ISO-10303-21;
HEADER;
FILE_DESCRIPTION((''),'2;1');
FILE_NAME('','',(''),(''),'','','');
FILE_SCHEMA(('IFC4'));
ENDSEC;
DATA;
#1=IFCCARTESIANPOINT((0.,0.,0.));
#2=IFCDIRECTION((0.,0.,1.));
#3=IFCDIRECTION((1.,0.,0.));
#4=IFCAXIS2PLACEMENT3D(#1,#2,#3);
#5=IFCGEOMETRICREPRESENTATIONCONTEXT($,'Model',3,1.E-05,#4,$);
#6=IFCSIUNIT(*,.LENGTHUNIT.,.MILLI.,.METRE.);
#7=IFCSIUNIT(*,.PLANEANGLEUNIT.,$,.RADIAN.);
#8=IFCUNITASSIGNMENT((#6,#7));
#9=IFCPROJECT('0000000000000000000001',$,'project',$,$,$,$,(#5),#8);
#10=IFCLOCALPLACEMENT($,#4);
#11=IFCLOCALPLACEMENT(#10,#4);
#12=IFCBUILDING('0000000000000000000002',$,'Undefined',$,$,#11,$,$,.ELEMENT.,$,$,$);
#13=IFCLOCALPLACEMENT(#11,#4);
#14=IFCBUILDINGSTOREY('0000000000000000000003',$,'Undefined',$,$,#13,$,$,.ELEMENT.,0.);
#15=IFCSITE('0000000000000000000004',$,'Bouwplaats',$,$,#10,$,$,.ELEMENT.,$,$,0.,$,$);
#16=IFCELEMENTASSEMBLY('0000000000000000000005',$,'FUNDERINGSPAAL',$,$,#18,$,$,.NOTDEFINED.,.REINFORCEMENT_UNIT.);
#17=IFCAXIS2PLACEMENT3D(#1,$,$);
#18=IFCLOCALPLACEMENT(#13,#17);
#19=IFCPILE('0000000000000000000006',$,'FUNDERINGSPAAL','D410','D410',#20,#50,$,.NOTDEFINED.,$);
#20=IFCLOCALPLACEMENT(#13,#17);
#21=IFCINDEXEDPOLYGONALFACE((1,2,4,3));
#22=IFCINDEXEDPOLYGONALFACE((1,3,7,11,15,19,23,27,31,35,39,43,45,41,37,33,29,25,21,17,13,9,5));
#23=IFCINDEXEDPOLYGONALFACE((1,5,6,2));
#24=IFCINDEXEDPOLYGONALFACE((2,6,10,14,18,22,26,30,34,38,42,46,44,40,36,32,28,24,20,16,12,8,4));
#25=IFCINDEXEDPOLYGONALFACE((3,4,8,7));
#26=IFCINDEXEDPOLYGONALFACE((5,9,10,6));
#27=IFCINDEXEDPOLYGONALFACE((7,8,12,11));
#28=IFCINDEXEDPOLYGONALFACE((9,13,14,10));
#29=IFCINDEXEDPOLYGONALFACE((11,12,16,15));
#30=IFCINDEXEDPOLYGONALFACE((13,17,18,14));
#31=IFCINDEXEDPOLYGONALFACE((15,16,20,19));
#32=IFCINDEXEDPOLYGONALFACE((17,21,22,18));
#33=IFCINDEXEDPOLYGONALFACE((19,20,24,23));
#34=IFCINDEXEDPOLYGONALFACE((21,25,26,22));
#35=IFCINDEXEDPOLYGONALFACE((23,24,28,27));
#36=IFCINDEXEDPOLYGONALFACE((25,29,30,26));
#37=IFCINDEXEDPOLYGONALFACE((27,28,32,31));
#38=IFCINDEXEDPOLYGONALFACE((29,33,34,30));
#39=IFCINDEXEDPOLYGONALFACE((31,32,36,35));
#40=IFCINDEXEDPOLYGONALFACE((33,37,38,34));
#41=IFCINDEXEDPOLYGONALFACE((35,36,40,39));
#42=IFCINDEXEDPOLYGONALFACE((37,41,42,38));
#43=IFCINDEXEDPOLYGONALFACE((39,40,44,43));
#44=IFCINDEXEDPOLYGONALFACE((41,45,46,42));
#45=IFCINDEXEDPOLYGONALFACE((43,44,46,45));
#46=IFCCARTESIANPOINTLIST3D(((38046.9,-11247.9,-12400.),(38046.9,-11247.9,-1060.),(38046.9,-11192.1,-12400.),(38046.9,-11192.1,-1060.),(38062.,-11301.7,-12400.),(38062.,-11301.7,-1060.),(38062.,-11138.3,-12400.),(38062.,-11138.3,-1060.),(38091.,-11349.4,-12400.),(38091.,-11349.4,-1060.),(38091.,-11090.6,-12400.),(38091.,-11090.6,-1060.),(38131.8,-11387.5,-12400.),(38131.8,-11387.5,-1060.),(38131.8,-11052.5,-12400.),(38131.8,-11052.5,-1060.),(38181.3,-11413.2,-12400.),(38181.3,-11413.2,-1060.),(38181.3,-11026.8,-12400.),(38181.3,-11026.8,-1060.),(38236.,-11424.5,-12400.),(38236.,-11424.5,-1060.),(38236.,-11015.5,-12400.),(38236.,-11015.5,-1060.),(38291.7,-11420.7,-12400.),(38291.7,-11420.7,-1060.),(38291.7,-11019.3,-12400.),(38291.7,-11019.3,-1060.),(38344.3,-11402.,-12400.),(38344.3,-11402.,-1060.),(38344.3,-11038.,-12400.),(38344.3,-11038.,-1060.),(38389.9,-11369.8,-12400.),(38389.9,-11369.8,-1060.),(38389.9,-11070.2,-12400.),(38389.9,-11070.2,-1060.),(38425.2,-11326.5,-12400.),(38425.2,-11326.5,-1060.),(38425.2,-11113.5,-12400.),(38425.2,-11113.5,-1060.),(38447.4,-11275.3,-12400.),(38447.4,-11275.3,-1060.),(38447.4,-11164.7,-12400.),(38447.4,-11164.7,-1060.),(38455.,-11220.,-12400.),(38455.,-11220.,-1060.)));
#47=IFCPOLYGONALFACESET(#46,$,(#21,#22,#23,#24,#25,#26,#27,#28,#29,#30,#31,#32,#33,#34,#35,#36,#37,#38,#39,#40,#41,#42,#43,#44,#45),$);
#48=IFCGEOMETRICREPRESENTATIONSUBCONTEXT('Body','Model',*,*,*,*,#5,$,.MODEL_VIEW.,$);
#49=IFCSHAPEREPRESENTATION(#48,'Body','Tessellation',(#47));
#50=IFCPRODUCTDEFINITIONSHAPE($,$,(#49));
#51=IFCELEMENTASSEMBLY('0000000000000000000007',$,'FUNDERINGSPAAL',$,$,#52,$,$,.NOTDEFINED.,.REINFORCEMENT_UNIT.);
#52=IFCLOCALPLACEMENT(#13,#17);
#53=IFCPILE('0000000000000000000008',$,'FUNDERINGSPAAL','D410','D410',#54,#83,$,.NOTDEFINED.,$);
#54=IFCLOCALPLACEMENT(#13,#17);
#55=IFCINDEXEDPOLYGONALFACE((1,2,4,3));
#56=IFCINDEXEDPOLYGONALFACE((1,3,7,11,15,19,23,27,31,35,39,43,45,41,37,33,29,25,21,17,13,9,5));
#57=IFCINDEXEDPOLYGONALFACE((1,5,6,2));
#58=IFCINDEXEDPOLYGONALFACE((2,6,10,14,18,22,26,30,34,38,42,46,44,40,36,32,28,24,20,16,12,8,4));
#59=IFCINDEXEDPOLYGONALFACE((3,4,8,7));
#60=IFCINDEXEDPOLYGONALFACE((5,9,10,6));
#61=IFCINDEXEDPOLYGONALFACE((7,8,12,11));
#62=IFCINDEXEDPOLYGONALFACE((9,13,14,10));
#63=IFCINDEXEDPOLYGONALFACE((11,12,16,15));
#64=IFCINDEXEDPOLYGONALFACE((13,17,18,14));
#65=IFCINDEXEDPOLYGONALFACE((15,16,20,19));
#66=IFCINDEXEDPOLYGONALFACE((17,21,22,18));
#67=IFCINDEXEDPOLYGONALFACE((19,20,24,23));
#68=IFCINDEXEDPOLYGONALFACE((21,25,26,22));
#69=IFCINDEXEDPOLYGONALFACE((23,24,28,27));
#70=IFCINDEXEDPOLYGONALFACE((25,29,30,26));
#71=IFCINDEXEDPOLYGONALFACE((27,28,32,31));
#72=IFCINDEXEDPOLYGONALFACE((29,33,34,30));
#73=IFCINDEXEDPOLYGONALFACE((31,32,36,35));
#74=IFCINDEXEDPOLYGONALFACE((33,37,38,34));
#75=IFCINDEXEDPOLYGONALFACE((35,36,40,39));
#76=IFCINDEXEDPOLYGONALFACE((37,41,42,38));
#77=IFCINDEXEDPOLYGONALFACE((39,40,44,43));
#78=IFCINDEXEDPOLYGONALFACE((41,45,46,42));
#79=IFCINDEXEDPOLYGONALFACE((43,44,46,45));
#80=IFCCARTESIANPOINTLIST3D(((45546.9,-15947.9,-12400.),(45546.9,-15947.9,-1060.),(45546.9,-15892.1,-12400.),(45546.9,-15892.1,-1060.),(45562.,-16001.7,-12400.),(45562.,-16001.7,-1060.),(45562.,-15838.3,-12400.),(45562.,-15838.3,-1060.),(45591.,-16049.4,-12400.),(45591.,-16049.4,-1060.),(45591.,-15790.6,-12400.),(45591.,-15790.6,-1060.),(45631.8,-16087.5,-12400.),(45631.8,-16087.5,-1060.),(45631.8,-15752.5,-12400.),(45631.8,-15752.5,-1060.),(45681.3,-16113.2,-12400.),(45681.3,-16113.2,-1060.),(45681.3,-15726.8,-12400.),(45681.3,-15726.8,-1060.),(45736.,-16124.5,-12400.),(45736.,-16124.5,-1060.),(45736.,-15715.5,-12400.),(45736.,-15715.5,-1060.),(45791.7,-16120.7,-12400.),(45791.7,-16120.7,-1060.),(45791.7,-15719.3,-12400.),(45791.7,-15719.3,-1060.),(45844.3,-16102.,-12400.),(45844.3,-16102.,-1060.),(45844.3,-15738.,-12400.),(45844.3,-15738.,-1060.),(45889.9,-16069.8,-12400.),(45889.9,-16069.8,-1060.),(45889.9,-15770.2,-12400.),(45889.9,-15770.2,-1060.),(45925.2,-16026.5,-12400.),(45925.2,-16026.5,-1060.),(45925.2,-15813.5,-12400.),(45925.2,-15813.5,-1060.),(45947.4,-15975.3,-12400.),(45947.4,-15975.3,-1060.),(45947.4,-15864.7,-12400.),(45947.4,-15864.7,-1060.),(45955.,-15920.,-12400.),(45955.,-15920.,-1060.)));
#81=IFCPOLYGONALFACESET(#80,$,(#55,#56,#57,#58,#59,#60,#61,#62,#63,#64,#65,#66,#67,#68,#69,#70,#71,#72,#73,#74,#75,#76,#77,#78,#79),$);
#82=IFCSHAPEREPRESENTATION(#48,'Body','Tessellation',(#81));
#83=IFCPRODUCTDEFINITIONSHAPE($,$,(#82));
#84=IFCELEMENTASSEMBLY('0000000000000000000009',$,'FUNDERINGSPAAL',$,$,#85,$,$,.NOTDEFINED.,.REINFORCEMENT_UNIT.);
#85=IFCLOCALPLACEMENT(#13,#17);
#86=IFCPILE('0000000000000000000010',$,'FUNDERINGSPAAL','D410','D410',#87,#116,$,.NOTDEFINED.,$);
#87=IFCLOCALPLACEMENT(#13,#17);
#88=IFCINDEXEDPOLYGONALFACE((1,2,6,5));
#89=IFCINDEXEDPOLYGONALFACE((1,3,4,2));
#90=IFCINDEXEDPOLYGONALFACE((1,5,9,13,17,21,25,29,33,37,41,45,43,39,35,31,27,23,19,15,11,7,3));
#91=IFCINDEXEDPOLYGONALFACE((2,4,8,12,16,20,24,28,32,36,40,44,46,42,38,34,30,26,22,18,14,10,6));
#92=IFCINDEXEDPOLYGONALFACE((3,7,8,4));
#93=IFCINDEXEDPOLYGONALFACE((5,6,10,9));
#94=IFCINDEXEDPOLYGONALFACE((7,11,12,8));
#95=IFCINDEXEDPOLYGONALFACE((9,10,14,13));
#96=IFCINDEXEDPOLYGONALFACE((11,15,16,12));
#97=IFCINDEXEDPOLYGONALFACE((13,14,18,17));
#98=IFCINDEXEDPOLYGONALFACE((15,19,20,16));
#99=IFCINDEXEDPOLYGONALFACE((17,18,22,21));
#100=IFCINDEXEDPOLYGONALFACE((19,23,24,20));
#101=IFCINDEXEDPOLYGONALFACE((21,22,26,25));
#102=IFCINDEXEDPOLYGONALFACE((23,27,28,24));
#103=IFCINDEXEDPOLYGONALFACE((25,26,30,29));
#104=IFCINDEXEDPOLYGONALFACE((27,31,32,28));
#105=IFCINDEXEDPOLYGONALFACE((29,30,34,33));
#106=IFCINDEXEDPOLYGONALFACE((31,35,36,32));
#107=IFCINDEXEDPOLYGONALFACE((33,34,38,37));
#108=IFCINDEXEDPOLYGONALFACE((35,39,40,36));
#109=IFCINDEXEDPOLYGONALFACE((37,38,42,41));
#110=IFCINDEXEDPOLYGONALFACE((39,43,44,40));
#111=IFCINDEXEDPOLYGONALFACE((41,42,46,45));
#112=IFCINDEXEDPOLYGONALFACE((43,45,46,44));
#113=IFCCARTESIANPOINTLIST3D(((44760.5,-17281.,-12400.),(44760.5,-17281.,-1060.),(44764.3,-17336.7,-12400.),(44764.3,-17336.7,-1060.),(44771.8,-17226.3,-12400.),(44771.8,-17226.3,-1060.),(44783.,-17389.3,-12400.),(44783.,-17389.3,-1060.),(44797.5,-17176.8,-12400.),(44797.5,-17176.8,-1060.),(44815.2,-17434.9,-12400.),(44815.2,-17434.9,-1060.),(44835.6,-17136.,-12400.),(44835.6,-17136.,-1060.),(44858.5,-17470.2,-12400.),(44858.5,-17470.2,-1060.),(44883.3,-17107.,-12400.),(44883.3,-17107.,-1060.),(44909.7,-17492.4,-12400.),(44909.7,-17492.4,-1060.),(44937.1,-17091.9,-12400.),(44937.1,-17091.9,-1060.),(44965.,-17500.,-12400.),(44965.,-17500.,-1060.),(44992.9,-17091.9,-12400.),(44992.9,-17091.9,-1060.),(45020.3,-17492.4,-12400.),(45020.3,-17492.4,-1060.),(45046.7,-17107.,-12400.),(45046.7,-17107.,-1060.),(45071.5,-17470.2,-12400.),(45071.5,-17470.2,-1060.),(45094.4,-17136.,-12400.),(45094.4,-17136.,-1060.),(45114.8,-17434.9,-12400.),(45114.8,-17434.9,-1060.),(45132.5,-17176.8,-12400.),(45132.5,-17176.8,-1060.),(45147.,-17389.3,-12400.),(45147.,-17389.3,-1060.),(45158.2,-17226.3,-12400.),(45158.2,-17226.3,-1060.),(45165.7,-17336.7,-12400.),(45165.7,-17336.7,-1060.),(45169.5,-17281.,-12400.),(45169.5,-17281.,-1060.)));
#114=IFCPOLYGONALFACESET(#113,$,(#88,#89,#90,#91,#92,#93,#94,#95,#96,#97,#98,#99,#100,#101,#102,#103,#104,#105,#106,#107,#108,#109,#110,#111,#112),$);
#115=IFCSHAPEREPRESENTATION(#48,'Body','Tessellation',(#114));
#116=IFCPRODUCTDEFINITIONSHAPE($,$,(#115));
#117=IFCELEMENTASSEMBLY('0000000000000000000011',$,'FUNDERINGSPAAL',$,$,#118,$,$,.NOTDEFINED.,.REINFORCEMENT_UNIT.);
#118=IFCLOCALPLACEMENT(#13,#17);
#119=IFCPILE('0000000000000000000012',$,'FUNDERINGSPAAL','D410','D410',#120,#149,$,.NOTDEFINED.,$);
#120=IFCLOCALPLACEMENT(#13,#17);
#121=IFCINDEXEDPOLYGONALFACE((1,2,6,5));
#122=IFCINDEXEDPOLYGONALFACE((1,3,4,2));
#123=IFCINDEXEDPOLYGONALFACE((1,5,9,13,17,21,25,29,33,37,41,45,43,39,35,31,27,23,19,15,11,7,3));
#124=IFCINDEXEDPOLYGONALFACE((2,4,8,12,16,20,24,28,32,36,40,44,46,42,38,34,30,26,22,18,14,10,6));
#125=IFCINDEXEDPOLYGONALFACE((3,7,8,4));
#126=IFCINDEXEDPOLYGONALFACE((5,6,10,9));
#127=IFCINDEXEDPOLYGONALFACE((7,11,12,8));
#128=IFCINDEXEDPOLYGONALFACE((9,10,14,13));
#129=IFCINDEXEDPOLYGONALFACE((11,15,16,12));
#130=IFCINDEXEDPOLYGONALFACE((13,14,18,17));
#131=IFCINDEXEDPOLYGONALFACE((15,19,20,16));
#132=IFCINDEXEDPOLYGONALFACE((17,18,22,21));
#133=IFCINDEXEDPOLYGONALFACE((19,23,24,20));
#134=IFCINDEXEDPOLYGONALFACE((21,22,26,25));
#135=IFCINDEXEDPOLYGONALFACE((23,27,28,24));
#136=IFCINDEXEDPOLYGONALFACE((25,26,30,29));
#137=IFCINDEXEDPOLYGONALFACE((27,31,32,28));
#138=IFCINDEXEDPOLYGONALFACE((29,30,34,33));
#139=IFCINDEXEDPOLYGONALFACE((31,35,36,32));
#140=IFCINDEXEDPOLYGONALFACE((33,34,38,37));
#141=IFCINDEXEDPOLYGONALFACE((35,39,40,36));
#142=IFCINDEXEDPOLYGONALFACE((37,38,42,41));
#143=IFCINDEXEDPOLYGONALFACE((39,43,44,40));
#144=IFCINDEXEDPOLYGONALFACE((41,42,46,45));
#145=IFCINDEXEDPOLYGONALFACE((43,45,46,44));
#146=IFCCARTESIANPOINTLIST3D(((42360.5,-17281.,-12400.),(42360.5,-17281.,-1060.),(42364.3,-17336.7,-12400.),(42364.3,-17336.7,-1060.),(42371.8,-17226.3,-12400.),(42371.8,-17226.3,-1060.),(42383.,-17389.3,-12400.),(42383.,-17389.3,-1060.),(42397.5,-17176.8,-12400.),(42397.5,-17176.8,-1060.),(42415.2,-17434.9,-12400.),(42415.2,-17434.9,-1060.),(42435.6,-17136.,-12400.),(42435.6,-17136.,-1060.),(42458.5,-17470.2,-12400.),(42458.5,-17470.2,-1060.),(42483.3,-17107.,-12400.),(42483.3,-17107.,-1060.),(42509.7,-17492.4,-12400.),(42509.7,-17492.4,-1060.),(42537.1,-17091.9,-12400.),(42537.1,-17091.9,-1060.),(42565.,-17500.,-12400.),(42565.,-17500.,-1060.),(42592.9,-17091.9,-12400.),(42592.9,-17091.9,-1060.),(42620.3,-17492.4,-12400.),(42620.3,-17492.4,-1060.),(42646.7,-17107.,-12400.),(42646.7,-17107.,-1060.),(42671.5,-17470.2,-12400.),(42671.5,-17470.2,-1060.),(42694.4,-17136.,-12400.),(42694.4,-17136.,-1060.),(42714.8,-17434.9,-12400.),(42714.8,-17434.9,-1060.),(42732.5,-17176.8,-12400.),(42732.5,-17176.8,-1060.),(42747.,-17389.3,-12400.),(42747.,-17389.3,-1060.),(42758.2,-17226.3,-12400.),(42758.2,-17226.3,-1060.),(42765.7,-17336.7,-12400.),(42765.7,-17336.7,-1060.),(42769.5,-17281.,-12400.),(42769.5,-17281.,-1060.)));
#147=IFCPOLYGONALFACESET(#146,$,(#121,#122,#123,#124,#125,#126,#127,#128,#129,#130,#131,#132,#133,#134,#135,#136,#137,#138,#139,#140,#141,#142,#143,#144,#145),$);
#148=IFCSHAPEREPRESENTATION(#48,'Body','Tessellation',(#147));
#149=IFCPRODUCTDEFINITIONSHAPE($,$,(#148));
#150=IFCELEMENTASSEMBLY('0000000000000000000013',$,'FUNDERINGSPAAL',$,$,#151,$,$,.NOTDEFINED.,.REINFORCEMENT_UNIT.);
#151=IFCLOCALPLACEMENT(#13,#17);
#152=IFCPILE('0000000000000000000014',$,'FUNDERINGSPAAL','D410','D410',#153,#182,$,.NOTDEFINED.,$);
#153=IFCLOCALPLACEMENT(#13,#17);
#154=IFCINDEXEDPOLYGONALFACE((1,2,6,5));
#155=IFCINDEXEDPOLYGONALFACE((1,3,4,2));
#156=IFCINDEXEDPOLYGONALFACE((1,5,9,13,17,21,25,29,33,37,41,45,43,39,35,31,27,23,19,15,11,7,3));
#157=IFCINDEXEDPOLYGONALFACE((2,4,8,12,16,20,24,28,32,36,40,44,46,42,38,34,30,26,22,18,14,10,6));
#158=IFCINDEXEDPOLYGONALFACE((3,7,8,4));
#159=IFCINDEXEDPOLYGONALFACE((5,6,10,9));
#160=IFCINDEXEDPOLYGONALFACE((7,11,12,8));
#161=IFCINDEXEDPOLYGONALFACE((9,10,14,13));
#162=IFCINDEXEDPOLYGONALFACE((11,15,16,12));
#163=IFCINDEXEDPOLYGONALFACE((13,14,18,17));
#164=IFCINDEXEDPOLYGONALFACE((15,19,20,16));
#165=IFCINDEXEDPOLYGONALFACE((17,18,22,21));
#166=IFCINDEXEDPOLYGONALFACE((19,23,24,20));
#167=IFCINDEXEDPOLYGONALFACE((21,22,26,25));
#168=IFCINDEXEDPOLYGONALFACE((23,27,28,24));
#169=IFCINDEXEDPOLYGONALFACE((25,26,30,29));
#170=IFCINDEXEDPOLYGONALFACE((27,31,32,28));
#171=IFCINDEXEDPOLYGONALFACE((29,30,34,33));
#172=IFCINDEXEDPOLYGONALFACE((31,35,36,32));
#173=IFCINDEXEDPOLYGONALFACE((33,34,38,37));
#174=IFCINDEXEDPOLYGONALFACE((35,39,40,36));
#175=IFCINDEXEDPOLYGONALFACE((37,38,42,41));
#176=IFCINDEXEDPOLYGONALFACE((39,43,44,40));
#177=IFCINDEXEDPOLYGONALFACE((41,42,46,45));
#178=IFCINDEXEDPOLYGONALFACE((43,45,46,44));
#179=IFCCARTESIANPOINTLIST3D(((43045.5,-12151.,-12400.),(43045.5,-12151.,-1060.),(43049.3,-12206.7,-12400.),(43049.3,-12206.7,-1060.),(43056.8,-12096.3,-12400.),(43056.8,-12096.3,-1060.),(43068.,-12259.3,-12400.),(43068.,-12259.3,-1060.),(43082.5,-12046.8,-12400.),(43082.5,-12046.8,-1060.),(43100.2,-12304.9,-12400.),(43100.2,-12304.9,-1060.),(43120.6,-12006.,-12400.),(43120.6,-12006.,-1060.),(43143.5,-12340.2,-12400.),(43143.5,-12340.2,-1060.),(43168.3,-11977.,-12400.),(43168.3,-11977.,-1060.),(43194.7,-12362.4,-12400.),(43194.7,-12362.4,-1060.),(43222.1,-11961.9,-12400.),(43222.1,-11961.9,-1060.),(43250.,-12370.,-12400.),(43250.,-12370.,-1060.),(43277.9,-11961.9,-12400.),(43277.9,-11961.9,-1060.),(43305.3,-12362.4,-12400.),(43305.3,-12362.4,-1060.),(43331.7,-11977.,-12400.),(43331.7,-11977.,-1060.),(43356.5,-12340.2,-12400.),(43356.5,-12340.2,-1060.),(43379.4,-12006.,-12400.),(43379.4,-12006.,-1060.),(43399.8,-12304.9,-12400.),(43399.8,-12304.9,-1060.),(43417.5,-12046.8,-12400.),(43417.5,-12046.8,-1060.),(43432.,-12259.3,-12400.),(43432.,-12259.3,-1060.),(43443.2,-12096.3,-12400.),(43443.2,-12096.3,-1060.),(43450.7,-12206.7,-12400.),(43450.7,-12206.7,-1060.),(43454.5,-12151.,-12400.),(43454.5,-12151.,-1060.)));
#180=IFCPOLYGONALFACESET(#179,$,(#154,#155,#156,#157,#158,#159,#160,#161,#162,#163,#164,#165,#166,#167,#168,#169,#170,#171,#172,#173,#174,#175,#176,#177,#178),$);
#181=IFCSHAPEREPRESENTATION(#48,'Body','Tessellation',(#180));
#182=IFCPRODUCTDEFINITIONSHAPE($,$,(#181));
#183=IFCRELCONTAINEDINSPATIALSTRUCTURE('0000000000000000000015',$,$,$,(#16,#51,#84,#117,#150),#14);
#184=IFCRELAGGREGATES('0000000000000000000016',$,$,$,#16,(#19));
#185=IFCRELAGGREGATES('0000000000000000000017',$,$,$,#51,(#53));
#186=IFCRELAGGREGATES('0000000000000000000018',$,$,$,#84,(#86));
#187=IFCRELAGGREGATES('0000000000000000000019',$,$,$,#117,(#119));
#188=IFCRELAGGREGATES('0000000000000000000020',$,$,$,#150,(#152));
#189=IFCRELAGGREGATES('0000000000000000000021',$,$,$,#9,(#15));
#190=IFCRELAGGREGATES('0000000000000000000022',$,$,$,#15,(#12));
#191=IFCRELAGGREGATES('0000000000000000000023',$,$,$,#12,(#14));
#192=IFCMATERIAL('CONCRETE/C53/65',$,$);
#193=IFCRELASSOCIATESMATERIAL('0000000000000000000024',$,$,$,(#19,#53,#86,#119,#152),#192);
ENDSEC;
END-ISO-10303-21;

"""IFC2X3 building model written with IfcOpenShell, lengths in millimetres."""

from ifc_helpers import new_model, si_unit, frame, origin_with_axes, origin_2d_with_axis, place, context, subcontext, project, spatial, circle, extrude, clip, halfspace, material, element, aggregate, save


model = new_model("IFC2X3")

# Units and contexts
model_context = context("Model", 3, precision=1e-05, world=origin_with_axes())
body_context = subcontext(model_context, "Body", "Model", "MODEL_VIEW")
ifc_project = project(units=[si_unit("LENGTHUNIT", "METRE", prefix="MILLI"), si_unit("PLANEANGLEUNIT", "RADIAN")], contexts=[model_context])

# Site, building, storey
site_placement = place(None, origin_with_axes())
site = spatial("IfcSite", under=ifc_project, at=site_placement, Name="Bouwplaats", CompositionType="ELEMENT", RefElevation=0.0)
building_placement = place(site_placement, origin_with_axes())
building = spatial("IfcBuilding", under=site, at=building_placement, Name="Undefined", CompositionType="ELEMENT")
storey_placement = place(building_placement, origin_with_axes())
storey = spatial("IfcBuildingStorey", under=building, at=storey_placement, Name="Undefined", CompositionType="ELEMENT", Elevation=0.0)

# Element assemblies, piles
assembly_1_placement = place(storey_placement, origin_with_axes())
assembly_1 = element("IfcElementAssembly", 1, at=assembly_1_placement, inside=storey, Name="FUNDERINGSPAAL", AssemblyPlace="NOTDEFINED", PredefinedType="REINFORCEMENT_UNIT")
ifc_material_1 = material(Name="CONCRETE/C53/65")
pile_1_placement = place(assembly_1_placement, frame((38250.0, -11220.0, -1060.0), z_axis=(0.0, 1.0, 0.0), x_axis=(0.0, 0.0, -1.0)))
pile_1 = element("IfcPile", 2, at=pile_1_placement, material=ifc_material_1, Name="FUNDERINGSPAAL", Description="D410", ObjectType="D410", PredefinedType="NOTDEFINED", context=body_context, shape_type="Clipping", body=[
    clip(extrude(circle(Radius=205.0, at=origin_2d_with_axis()), frame((11340.0, 0.0, 0.0), z_axis=(-1.0, 0.0, 0.0), x_axis=(0.0, -1.0, 0.0)), (0.0, 0.0, 1.0), 11340.0), halfspace(frame((0.0, 205.0, -205.0), z_axis=(-1.0, 0.0, 0.0), x_axis=(0.0, 0.0, 1.0)), False)),
])
aggregate(assembly_1, [pile_1])
assembly_2_placement = place(storey_placement, origin_with_axes())
assembly_2 = element("IfcElementAssembly", 3, at=assembly_2_placement, inside=storey, Name="FUNDERINGSPAAL", AssemblyPlace="NOTDEFINED", PredefinedType="REINFORCEMENT_UNIT")
pile_2_placement = place(assembly_2_placement, frame((45750.0, -15920.0, -1060.0), z_axis=(0.0, 1.0, 0.0), x_axis=(0.0, 0.0, -1.0)))
pile_2 = element("IfcPile", 4, at=pile_2_placement, material=ifc_material_1, Name="FUNDERINGSPAAL", Description="D410", ObjectType="D410", PredefinedType="NOTDEFINED", context=body_context, shape_type="Clipping", body=[
    clip(extrude(circle(Radius=205.0, at=origin_2d_with_axis()), frame((11340.0, 0.0, 0.0), z_axis=(-1.0, 0.0, 0.0), x_axis=(0.0, -1.0, 0.0)), (0.0, 0.0, 1.0), 11340.0), halfspace(frame((0.0, 205.0, -205.0), z_axis=(-1.0, 0.0, 0.0), x_axis=(0.0, 0.0, 1.0)), False)),
])
aggregate(assembly_2, [pile_2])
assembly_3_placement = place(storey_placement, origin_with_axes())
assembly_3 = element("IfcElementAssembly", 5, at=assembly_3_placement, inside=storey, Name="FUNDERINGSPAAL", AssemblyPlace="NOTDEFINED", PredefinedType="REINFORCEMENT_UNIT")
pile_3_placement = place(assembly_3_placement, frame((44965.0, -17295.0, -1060.0), z_axis=(1.0, 0.0, 0.0), x_axis=(0.0, 0.0, -1.0)))
pile_3 = element("IfcPile", 6, at=pile_3_placement, material=ifc_material_1, Name="FUNDERINGSPAAL", Description="D410", ObjectType="D410", PredefinedType="NOTDEFINED", context=body_context, shape_type="Clipping", body=[
    clip(extrude(circle(Radius=205.0, at=origin_2d_with_axis()), frame((11340.0, 0.0, 0.0), z_axis=(-1.0, 0.0, 0.0), x_axis=(0.0, -1.0, 0.0)), (0.0, 0.0, 1.0), 11340.0), halfspace(frame((0.0, 205.0, -205.0), z_axis=(-1.0, 0.0, 0.0), x_axis=(0.0, 0.0, 1.0)), False)),
])
aggregate(assembly_3, [pile_3])
assembly_4_placement = place(storey_placement, origin_with_axes())
assembly_4 = element("IfcElementAssembly", 7, at=assembly_4_placement, inside=storey, Name="FUNDERINGSPAAL", AssemblyPlace="NOTDEFINED", PredefinedType="REINFORCEMENT_UNIT")
pile_4_placement = place(assembly_4_placement, frame((42565.0, -17295.0, -1060.0), z_axis=(1.0, 0.0, 0.0), x_axis=(0.0, 0.0, -1.0)))
pile_4 = element("IfcPile", 8, at=pile_4_placement, material=ifc_material_1, Name="FUNDERINGSPAAL", Description="D410", ObjectType="D410", PredefinedType="NOTDEFINED", context=body_context, shape_type="Clipping", body=[
    clip(extrude(circle(Radius=205.0, at=origin_2d_with_axis()), frame((11340.0, 0.0, 0.0), z_axis=(-1.0, 0.0, 0.0), x_axis=(0.0, -1.0, 0.0)), (0.0, 0.0, 1.0), 11340.0), halfspace(frame((0.0, 205.0, -205.0), z_axis=(-1.0, 0.0, 0.0), x_axis=(0.0, 0.0, 1.0)), False)),
])
aggregate(assembly_4, [pile_4])
assembly_5_placement = place(storey_placement, origin_with_axes())
assembly_5 = element("IfcElementAssembly", 9, at=assembly_5_placement, inside=storey, Name="FUNDERINGSPAAL", AssemblyPlace="NOTDEFINED", PredefinedType="REINFORCEMENT_UNIT")
pile_5_placement = place(assembly_5_placement, frame((43250.0, -12165.0, -1060.0), z_axis=(1.0, 0.0, 0.0), x_axis=(0.0, 0.0, -1.0)))
pile_5 = element("IfcPile", 10, at=pile_5_placement, material=ifc_material_1, Name="FUNDERINGSPAAL", Description="D410", ObjectType="D410", PredefinedType="NOTDEFINED", context=body_context, shape_type="Clipping", body=[
    clip(extrude(circle(Radius=205.0, at=origin_2d_with_axis()), frame((11340.0, 0.0, 0.0), z_axis=(-1.0, 0.0, 0.0), x_axis=(0.0, -1.0, 0.0)), (0.0, 0.0, 1.0), 11340.0), halfspace(frame((0.0, 205.0, -205.0), z_axis=(-1.0, 0.0, 0.0), x_axis=(0.0, 0.0, 1.0)), False)),
])
aggregate(assembly_5, [pile_5])

save(model, "model.ifc")
